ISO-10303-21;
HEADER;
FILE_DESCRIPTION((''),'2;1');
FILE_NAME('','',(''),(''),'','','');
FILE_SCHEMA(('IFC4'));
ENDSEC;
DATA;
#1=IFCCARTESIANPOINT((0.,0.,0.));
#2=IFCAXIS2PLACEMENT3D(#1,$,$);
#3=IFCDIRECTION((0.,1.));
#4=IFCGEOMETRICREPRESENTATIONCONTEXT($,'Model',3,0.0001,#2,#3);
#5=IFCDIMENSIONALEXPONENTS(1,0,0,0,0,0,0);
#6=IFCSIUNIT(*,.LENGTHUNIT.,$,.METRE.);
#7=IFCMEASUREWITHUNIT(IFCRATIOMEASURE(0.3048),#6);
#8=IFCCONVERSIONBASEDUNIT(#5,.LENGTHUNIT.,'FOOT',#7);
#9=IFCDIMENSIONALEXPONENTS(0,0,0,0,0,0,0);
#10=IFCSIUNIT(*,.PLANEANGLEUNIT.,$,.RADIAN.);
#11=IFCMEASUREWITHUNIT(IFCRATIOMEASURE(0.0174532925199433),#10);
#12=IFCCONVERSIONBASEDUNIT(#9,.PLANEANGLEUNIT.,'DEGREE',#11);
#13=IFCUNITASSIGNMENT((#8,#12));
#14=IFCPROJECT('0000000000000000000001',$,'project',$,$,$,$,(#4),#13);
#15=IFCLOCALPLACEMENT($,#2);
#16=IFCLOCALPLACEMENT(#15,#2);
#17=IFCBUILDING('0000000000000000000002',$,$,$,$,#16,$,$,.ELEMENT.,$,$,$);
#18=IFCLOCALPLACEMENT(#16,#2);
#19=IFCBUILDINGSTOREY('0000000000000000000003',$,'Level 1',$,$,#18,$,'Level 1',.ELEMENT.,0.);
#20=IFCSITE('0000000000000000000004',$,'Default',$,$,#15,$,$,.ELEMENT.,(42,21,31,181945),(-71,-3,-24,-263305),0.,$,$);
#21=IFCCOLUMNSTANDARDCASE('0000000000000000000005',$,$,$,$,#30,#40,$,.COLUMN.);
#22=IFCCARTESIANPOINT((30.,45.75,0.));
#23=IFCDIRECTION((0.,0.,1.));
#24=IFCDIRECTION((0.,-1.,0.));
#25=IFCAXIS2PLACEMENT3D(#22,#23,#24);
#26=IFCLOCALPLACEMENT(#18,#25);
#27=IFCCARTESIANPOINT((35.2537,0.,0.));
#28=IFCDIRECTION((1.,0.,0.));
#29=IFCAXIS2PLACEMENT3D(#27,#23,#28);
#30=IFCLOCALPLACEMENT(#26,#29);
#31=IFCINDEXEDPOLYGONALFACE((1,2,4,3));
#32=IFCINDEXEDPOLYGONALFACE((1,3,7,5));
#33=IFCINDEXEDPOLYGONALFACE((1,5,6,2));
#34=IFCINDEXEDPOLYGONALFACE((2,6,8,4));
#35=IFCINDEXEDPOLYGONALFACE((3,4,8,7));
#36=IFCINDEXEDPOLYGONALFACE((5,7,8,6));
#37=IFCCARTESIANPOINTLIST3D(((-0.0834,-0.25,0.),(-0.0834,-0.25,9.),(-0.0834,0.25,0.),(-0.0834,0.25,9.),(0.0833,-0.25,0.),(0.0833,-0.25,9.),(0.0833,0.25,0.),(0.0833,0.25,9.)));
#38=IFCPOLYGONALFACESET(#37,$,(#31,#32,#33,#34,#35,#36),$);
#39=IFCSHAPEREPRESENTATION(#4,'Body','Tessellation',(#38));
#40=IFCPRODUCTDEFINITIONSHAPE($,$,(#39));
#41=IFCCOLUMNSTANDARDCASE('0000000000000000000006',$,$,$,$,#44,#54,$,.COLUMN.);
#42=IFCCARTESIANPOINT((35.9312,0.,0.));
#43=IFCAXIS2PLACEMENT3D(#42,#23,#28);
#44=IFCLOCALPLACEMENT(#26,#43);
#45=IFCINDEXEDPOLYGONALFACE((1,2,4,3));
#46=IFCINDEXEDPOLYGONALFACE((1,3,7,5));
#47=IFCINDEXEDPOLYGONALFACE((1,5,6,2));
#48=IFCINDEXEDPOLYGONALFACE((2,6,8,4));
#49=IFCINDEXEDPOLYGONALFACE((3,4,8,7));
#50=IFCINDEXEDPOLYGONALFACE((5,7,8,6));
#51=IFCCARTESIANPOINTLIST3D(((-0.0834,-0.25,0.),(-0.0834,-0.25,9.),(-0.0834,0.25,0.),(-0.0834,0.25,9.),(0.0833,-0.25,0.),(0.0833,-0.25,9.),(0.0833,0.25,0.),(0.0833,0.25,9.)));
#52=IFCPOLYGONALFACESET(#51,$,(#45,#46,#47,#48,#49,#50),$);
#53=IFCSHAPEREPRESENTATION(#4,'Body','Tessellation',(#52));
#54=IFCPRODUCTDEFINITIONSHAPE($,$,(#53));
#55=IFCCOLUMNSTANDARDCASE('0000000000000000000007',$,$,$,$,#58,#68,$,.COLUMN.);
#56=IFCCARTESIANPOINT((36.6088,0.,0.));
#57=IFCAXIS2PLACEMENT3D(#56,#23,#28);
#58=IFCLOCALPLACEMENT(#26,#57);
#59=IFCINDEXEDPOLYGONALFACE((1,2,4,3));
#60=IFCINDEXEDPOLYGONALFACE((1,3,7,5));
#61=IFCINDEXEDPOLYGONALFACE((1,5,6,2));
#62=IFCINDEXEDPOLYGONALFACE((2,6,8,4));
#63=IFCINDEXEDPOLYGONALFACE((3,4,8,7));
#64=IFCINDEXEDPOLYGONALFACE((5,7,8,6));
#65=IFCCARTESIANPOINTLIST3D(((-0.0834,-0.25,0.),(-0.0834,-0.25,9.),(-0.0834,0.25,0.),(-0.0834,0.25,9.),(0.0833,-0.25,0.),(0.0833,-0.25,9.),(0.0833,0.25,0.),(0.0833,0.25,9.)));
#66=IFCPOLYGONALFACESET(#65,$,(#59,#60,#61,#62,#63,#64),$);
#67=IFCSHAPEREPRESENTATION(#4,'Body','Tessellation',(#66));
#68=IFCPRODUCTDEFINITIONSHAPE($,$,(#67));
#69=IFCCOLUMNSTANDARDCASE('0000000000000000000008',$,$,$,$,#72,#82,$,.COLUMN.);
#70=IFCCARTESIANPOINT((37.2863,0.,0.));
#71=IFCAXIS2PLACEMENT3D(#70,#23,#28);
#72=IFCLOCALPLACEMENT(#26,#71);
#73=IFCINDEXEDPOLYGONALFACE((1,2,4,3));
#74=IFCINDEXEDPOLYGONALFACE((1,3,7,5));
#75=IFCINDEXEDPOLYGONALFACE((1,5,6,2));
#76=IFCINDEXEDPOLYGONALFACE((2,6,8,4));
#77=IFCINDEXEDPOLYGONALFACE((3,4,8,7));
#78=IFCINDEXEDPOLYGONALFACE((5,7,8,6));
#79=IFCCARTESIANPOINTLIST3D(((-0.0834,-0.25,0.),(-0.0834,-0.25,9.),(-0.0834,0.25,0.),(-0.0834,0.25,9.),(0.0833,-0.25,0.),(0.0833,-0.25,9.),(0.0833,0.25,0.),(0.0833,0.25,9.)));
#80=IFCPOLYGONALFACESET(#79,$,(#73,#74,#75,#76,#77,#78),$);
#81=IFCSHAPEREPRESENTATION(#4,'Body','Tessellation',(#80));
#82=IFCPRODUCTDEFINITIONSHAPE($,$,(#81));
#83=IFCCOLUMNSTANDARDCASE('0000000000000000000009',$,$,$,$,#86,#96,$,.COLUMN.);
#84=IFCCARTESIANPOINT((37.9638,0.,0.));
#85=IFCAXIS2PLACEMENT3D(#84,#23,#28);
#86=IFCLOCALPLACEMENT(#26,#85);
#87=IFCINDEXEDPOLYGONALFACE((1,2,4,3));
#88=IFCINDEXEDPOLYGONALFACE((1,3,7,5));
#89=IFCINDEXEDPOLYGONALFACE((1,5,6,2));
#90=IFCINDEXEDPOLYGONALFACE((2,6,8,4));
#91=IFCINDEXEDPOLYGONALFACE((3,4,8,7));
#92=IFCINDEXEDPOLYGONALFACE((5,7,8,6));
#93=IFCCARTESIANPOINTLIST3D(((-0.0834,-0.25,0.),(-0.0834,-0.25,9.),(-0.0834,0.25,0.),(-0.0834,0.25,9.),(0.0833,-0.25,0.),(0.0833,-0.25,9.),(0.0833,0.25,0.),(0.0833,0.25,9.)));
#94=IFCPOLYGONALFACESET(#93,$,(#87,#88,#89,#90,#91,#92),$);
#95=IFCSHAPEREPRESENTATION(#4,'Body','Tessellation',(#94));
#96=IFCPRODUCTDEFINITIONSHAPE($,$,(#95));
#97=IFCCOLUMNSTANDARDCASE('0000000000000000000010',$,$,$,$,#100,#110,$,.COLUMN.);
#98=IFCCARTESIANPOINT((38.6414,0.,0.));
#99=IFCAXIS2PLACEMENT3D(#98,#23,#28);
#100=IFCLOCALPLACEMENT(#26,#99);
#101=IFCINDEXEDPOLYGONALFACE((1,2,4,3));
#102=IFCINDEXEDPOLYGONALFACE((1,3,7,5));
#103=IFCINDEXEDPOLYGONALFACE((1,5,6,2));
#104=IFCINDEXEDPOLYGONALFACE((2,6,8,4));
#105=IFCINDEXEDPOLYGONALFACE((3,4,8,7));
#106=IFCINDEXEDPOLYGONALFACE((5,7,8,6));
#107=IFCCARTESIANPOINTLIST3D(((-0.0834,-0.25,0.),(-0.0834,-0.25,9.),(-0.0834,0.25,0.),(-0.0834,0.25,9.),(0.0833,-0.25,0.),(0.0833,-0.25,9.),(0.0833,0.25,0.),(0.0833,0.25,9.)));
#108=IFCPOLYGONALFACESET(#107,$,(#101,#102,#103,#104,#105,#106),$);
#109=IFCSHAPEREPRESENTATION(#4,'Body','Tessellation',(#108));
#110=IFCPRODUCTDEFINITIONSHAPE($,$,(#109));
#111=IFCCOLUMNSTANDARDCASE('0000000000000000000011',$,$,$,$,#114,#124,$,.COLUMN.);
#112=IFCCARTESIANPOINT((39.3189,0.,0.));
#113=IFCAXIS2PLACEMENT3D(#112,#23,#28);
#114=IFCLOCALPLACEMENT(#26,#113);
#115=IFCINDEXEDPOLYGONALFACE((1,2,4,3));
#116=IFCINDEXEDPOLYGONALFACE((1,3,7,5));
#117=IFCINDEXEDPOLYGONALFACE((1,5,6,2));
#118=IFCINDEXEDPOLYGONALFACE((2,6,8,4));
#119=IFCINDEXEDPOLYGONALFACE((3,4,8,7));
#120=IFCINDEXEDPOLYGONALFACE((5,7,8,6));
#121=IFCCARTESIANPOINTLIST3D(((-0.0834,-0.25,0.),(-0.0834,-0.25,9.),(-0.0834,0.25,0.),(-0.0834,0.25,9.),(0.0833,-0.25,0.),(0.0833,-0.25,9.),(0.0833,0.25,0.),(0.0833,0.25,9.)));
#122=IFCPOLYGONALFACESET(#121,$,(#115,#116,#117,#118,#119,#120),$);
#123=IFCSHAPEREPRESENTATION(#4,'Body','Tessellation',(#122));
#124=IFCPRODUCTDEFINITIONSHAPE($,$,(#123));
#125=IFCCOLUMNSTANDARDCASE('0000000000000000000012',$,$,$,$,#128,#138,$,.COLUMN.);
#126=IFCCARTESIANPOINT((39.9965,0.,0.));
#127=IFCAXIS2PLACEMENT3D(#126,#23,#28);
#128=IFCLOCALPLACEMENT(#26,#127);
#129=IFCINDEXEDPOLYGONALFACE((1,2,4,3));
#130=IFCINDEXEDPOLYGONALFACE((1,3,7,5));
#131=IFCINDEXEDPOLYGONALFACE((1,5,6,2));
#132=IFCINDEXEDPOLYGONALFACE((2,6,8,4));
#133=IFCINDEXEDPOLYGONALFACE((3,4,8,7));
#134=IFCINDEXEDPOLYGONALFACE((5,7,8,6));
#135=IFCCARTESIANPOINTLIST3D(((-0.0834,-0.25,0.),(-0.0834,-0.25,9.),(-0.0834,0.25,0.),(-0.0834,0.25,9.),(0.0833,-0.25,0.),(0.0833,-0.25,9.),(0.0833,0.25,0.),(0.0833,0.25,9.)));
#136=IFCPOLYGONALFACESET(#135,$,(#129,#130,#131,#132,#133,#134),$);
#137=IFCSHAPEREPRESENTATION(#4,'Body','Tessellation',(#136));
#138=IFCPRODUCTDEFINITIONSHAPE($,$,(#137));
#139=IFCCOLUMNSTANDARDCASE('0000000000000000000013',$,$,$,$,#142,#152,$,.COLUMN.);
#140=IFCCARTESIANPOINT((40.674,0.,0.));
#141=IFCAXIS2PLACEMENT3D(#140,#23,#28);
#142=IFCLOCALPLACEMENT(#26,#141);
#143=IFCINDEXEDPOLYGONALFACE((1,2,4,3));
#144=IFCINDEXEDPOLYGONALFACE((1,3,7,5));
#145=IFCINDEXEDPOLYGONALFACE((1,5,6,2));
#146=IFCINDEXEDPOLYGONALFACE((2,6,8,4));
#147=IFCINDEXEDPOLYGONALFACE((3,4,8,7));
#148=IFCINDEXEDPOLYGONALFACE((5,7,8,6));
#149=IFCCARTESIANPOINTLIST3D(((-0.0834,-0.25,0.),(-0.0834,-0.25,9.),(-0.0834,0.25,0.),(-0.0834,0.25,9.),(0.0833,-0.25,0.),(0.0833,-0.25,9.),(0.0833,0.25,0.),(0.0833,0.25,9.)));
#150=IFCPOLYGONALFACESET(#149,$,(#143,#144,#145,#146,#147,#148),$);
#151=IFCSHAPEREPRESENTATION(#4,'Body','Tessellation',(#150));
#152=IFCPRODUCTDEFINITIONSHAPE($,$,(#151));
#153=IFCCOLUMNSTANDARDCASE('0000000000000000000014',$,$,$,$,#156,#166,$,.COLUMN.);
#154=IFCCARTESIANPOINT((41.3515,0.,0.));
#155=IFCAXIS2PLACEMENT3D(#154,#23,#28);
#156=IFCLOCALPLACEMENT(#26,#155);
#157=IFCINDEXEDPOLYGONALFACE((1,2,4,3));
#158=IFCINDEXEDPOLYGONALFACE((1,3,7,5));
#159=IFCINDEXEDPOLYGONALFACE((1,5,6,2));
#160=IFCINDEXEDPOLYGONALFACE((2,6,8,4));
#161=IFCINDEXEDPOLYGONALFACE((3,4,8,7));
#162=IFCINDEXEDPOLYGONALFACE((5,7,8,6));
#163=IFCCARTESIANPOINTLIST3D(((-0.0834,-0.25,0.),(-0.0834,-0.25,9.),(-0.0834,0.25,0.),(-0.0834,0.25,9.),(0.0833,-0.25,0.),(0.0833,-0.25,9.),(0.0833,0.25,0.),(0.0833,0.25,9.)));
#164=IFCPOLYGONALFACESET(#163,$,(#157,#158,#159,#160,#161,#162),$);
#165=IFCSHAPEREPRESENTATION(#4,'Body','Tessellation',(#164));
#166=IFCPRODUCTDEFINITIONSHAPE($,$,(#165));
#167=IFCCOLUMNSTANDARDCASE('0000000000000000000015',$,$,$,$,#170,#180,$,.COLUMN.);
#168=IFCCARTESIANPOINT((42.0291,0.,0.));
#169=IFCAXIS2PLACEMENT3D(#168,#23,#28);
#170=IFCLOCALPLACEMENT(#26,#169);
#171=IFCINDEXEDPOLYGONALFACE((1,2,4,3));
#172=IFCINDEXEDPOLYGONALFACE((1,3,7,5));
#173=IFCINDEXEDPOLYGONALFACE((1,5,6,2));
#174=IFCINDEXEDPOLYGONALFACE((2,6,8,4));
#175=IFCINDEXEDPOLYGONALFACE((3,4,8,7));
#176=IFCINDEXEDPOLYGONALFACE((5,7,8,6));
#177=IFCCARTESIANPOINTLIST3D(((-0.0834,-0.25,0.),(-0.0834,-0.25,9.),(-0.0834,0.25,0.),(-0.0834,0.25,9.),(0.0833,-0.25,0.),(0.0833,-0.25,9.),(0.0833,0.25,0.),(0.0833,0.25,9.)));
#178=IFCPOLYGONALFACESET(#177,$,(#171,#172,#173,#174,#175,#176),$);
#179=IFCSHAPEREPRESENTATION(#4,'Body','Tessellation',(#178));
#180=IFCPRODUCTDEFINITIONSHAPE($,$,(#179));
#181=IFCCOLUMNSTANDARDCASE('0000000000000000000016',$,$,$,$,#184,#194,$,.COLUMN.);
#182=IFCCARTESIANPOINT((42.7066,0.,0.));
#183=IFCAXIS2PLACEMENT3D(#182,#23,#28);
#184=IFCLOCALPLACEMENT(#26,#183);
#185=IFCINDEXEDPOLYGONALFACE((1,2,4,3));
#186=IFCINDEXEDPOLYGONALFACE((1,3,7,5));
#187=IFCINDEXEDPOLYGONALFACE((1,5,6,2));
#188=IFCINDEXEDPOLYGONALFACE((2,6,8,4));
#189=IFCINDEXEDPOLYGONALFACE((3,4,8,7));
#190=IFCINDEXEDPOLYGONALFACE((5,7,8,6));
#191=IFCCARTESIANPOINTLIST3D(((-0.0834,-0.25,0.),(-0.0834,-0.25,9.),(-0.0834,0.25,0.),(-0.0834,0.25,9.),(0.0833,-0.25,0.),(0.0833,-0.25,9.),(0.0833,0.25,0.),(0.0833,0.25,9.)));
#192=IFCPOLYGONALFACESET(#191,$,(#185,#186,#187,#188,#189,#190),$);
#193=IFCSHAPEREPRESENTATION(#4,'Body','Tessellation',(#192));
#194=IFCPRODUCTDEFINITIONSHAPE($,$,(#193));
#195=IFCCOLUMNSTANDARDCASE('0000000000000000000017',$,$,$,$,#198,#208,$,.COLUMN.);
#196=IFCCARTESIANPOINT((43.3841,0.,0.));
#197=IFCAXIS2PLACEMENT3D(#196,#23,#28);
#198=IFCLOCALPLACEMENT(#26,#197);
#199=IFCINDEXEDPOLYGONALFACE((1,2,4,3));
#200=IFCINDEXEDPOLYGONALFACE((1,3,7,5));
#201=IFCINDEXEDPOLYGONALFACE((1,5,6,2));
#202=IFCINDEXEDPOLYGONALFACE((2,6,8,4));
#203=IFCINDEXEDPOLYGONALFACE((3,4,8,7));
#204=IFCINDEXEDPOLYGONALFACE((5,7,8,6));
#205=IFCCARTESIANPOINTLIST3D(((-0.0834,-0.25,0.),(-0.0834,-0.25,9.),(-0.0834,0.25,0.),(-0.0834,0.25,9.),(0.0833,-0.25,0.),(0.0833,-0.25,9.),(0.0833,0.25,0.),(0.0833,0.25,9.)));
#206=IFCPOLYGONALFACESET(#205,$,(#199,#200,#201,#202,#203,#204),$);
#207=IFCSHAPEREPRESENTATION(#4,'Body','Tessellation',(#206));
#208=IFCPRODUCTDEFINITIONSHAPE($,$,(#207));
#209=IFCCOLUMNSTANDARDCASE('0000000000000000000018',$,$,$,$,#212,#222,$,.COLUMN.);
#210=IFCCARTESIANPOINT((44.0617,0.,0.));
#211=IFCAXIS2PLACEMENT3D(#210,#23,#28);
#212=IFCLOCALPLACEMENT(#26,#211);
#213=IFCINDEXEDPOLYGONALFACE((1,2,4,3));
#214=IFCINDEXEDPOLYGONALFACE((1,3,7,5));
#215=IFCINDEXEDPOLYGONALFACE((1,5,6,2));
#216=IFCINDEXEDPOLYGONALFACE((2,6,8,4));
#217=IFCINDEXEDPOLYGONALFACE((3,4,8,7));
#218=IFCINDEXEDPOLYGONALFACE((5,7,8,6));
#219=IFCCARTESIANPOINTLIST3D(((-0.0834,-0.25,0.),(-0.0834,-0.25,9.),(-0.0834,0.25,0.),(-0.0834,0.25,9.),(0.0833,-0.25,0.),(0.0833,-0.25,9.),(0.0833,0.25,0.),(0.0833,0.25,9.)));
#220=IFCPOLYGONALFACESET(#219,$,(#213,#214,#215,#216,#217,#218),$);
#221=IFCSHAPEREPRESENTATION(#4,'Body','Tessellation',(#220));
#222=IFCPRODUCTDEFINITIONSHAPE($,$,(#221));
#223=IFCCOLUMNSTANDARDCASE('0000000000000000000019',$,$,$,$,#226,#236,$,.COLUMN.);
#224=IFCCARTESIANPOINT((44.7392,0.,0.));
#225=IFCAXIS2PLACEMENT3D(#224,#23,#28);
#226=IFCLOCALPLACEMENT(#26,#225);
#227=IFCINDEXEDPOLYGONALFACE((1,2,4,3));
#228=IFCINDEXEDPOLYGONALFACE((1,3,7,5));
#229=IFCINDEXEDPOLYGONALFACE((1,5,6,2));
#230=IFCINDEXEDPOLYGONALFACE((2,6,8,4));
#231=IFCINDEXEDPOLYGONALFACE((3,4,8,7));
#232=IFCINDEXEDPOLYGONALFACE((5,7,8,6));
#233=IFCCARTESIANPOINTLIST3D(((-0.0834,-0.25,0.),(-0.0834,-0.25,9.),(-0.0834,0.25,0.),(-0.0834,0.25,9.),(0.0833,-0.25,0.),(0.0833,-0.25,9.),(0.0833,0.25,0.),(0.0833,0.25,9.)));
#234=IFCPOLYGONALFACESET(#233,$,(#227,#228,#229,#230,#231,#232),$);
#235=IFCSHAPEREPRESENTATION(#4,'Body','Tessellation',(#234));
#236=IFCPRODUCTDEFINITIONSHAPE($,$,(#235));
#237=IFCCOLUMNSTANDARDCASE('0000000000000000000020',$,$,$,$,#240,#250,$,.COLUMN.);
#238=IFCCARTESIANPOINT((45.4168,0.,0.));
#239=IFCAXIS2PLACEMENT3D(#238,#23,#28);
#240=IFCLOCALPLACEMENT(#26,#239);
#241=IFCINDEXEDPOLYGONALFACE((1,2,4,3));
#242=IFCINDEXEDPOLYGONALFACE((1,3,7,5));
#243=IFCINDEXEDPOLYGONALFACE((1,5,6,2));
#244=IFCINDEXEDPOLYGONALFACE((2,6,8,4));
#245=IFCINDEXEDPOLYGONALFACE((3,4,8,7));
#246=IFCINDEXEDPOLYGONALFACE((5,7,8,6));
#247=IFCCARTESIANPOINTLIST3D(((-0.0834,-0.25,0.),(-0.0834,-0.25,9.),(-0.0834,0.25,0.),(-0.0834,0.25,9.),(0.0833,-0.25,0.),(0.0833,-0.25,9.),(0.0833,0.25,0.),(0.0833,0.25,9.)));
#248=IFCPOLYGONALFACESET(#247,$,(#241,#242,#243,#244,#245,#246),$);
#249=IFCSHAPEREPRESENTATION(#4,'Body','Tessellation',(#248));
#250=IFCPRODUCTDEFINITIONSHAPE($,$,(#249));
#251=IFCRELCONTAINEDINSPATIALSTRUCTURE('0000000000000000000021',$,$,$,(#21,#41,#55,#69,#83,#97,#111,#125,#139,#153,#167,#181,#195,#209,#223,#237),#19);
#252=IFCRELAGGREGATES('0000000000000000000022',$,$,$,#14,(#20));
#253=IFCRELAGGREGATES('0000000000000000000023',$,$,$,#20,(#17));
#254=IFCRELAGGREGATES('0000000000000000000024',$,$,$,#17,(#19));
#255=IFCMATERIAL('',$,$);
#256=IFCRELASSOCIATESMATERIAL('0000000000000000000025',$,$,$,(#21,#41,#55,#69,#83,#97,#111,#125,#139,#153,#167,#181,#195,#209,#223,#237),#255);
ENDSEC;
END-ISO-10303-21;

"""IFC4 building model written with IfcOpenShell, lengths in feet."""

from ifc_helpers import new_model, entity, si_unit, converted_unit, direction, frame, origin, place, context, project, spatial, rectangle, extrude, material, element, save


model = new_model("IFC4")

# Units and contexts
model_context = context("Model", 3, precision=0.0001, world=origin(), true_north=direction((0.0, 1.0)))
ifc_project = project(units=[converted_unit("LENGTHUNIT", "FOOT", entity("IfcRatioMeasure", 0.3048), si_unit("LENGTHUNIT", "METRE"), dimensions=[1, 0, 0, 0, 0, 0, 0]), converted_unit("PLANEANGLEUNIT", "DEGREE", entity("IfcRatioMeasure", 0.0174532925199433), si_unit("PLANEANGLEUNIT", "RADIAN"), dimensions=[0, 0, 0, 0, 0, 0, 0])], contexts=[model_context])

# Site, building, storey
site_placement = place(None, origin())
site = spatial("IfcSite", under=ifc_project, at=site_placement, Name="Default", CompositionType="ELEMENT", RefLatitude=(42, 21, 31, 181945), RefLongitude=(-71, -3, -24, -263305), RefElevation=0.0)
building_placement = place(site_placement, origin())
building = spatial("IfcBuilding", under=site, at=building_placement, CompositionType="ELEMENT")
storey_placement = place(building_placement, origin())
storey = spatial("IfcBuildingStorey", under=building, at=storey_placement, Name="Level 1", LongName="Level 1", CompositionType="ELEMENT", Elevation=0.0)

# Columns
ifc_material_1 = material(Name="")
placement_1 = place(storey_placement, frame((30.0, 45.75, 0.0), z_axis=(0.0, 0.0, 1.0), x_axis=(0.0, -1.0, 0.0)))
for number, where, z_axis, x_axis in (
    (1, (35.2537, 0.0, 0.0), (0.0, 0.0, 1.0), (1.0, 0.0, 0.0)),
    (2, (35.9312, 0.0, 0.0), (0.0, 0.0, 1.0), (1.0, 0.0, 0.0)),
    (3, (36.6088, 0.0, 0.0), (0.0, 0.0, 1.0), (1.0, 0.0, 0.0)),
    (4, (37.2863, 0.0, 0.0), (0.0, 0.0, 1.0), (1.0, 0.0, 0.0)),
    (5, (37.9638, 0.0, 0.0), (0.0, 0.0, 1.0), (1.0, 0.0, 0.0)),
    (6, (38.6414, 0.0, 0.0), (0.0, 0.0, 1.0), (1.0, 0.0, 0.0)),
    (7, (39.3189, 0.0, 0.0), (0.0, 0.0, 1.0), (1.0, 0.0, 0.0)),
    (8, (39.9965, 0.0, 0.0), (0.0, 0.0, 1.0), (1.0, 0.0, 0.0)),
    (9, (40.674, 0.0, 0.0), (0.0, 0.0, 1.0), (1.0, 0.0, 0.0)),
    (10, (41.3515, 0.0, 0.0), (0.0, 0.0, 1.0), (1.0, 0.0, 0.0)),
    (11, (42.0291, 0.0, 0.0), (0.0, 0.0, 1.0), (1.0, 0.0, 0.0)),
    (12, (42.7066, 0.0, 0.0), (0.0, 0.0, 1.0), (1.0, 0.0, 0.0)),
    (13, (43.3841, 0.0, 0.0), (0.0, 0.0, 1.0), (1.0, 0.0, 0.0)),
    (14, (44.0617, 0.0, 0.0), (0.0, 0.0, 1.0), (1.0, 0.0, 0.0)),
    (15, (44.7392, 0.0, 0.0), (0.0, 0.0, 1.0), (1.0, 0.0, 0.0)),
    (16, (45.4168, 0.0, 0.0), (0.0, 0.0, 1.0), (1.0, 0.0, 0.0)),
):
    element("IfcColumnStandardCase", number, at=place(placement_1, frame(where, z_axis=z_axis, x_axis=x_axis)), inside=storey, material=ifc_material_1, PredefinedType="COLUMN", context=model_context, shape_type="SweptSolid", body=[
        extrude(rectangle(XDim=0.1667, YDim=0.5), origin(), (0.0, 0.0, 1.0), 9.0),
    ])

save(model, "model.ifc")
